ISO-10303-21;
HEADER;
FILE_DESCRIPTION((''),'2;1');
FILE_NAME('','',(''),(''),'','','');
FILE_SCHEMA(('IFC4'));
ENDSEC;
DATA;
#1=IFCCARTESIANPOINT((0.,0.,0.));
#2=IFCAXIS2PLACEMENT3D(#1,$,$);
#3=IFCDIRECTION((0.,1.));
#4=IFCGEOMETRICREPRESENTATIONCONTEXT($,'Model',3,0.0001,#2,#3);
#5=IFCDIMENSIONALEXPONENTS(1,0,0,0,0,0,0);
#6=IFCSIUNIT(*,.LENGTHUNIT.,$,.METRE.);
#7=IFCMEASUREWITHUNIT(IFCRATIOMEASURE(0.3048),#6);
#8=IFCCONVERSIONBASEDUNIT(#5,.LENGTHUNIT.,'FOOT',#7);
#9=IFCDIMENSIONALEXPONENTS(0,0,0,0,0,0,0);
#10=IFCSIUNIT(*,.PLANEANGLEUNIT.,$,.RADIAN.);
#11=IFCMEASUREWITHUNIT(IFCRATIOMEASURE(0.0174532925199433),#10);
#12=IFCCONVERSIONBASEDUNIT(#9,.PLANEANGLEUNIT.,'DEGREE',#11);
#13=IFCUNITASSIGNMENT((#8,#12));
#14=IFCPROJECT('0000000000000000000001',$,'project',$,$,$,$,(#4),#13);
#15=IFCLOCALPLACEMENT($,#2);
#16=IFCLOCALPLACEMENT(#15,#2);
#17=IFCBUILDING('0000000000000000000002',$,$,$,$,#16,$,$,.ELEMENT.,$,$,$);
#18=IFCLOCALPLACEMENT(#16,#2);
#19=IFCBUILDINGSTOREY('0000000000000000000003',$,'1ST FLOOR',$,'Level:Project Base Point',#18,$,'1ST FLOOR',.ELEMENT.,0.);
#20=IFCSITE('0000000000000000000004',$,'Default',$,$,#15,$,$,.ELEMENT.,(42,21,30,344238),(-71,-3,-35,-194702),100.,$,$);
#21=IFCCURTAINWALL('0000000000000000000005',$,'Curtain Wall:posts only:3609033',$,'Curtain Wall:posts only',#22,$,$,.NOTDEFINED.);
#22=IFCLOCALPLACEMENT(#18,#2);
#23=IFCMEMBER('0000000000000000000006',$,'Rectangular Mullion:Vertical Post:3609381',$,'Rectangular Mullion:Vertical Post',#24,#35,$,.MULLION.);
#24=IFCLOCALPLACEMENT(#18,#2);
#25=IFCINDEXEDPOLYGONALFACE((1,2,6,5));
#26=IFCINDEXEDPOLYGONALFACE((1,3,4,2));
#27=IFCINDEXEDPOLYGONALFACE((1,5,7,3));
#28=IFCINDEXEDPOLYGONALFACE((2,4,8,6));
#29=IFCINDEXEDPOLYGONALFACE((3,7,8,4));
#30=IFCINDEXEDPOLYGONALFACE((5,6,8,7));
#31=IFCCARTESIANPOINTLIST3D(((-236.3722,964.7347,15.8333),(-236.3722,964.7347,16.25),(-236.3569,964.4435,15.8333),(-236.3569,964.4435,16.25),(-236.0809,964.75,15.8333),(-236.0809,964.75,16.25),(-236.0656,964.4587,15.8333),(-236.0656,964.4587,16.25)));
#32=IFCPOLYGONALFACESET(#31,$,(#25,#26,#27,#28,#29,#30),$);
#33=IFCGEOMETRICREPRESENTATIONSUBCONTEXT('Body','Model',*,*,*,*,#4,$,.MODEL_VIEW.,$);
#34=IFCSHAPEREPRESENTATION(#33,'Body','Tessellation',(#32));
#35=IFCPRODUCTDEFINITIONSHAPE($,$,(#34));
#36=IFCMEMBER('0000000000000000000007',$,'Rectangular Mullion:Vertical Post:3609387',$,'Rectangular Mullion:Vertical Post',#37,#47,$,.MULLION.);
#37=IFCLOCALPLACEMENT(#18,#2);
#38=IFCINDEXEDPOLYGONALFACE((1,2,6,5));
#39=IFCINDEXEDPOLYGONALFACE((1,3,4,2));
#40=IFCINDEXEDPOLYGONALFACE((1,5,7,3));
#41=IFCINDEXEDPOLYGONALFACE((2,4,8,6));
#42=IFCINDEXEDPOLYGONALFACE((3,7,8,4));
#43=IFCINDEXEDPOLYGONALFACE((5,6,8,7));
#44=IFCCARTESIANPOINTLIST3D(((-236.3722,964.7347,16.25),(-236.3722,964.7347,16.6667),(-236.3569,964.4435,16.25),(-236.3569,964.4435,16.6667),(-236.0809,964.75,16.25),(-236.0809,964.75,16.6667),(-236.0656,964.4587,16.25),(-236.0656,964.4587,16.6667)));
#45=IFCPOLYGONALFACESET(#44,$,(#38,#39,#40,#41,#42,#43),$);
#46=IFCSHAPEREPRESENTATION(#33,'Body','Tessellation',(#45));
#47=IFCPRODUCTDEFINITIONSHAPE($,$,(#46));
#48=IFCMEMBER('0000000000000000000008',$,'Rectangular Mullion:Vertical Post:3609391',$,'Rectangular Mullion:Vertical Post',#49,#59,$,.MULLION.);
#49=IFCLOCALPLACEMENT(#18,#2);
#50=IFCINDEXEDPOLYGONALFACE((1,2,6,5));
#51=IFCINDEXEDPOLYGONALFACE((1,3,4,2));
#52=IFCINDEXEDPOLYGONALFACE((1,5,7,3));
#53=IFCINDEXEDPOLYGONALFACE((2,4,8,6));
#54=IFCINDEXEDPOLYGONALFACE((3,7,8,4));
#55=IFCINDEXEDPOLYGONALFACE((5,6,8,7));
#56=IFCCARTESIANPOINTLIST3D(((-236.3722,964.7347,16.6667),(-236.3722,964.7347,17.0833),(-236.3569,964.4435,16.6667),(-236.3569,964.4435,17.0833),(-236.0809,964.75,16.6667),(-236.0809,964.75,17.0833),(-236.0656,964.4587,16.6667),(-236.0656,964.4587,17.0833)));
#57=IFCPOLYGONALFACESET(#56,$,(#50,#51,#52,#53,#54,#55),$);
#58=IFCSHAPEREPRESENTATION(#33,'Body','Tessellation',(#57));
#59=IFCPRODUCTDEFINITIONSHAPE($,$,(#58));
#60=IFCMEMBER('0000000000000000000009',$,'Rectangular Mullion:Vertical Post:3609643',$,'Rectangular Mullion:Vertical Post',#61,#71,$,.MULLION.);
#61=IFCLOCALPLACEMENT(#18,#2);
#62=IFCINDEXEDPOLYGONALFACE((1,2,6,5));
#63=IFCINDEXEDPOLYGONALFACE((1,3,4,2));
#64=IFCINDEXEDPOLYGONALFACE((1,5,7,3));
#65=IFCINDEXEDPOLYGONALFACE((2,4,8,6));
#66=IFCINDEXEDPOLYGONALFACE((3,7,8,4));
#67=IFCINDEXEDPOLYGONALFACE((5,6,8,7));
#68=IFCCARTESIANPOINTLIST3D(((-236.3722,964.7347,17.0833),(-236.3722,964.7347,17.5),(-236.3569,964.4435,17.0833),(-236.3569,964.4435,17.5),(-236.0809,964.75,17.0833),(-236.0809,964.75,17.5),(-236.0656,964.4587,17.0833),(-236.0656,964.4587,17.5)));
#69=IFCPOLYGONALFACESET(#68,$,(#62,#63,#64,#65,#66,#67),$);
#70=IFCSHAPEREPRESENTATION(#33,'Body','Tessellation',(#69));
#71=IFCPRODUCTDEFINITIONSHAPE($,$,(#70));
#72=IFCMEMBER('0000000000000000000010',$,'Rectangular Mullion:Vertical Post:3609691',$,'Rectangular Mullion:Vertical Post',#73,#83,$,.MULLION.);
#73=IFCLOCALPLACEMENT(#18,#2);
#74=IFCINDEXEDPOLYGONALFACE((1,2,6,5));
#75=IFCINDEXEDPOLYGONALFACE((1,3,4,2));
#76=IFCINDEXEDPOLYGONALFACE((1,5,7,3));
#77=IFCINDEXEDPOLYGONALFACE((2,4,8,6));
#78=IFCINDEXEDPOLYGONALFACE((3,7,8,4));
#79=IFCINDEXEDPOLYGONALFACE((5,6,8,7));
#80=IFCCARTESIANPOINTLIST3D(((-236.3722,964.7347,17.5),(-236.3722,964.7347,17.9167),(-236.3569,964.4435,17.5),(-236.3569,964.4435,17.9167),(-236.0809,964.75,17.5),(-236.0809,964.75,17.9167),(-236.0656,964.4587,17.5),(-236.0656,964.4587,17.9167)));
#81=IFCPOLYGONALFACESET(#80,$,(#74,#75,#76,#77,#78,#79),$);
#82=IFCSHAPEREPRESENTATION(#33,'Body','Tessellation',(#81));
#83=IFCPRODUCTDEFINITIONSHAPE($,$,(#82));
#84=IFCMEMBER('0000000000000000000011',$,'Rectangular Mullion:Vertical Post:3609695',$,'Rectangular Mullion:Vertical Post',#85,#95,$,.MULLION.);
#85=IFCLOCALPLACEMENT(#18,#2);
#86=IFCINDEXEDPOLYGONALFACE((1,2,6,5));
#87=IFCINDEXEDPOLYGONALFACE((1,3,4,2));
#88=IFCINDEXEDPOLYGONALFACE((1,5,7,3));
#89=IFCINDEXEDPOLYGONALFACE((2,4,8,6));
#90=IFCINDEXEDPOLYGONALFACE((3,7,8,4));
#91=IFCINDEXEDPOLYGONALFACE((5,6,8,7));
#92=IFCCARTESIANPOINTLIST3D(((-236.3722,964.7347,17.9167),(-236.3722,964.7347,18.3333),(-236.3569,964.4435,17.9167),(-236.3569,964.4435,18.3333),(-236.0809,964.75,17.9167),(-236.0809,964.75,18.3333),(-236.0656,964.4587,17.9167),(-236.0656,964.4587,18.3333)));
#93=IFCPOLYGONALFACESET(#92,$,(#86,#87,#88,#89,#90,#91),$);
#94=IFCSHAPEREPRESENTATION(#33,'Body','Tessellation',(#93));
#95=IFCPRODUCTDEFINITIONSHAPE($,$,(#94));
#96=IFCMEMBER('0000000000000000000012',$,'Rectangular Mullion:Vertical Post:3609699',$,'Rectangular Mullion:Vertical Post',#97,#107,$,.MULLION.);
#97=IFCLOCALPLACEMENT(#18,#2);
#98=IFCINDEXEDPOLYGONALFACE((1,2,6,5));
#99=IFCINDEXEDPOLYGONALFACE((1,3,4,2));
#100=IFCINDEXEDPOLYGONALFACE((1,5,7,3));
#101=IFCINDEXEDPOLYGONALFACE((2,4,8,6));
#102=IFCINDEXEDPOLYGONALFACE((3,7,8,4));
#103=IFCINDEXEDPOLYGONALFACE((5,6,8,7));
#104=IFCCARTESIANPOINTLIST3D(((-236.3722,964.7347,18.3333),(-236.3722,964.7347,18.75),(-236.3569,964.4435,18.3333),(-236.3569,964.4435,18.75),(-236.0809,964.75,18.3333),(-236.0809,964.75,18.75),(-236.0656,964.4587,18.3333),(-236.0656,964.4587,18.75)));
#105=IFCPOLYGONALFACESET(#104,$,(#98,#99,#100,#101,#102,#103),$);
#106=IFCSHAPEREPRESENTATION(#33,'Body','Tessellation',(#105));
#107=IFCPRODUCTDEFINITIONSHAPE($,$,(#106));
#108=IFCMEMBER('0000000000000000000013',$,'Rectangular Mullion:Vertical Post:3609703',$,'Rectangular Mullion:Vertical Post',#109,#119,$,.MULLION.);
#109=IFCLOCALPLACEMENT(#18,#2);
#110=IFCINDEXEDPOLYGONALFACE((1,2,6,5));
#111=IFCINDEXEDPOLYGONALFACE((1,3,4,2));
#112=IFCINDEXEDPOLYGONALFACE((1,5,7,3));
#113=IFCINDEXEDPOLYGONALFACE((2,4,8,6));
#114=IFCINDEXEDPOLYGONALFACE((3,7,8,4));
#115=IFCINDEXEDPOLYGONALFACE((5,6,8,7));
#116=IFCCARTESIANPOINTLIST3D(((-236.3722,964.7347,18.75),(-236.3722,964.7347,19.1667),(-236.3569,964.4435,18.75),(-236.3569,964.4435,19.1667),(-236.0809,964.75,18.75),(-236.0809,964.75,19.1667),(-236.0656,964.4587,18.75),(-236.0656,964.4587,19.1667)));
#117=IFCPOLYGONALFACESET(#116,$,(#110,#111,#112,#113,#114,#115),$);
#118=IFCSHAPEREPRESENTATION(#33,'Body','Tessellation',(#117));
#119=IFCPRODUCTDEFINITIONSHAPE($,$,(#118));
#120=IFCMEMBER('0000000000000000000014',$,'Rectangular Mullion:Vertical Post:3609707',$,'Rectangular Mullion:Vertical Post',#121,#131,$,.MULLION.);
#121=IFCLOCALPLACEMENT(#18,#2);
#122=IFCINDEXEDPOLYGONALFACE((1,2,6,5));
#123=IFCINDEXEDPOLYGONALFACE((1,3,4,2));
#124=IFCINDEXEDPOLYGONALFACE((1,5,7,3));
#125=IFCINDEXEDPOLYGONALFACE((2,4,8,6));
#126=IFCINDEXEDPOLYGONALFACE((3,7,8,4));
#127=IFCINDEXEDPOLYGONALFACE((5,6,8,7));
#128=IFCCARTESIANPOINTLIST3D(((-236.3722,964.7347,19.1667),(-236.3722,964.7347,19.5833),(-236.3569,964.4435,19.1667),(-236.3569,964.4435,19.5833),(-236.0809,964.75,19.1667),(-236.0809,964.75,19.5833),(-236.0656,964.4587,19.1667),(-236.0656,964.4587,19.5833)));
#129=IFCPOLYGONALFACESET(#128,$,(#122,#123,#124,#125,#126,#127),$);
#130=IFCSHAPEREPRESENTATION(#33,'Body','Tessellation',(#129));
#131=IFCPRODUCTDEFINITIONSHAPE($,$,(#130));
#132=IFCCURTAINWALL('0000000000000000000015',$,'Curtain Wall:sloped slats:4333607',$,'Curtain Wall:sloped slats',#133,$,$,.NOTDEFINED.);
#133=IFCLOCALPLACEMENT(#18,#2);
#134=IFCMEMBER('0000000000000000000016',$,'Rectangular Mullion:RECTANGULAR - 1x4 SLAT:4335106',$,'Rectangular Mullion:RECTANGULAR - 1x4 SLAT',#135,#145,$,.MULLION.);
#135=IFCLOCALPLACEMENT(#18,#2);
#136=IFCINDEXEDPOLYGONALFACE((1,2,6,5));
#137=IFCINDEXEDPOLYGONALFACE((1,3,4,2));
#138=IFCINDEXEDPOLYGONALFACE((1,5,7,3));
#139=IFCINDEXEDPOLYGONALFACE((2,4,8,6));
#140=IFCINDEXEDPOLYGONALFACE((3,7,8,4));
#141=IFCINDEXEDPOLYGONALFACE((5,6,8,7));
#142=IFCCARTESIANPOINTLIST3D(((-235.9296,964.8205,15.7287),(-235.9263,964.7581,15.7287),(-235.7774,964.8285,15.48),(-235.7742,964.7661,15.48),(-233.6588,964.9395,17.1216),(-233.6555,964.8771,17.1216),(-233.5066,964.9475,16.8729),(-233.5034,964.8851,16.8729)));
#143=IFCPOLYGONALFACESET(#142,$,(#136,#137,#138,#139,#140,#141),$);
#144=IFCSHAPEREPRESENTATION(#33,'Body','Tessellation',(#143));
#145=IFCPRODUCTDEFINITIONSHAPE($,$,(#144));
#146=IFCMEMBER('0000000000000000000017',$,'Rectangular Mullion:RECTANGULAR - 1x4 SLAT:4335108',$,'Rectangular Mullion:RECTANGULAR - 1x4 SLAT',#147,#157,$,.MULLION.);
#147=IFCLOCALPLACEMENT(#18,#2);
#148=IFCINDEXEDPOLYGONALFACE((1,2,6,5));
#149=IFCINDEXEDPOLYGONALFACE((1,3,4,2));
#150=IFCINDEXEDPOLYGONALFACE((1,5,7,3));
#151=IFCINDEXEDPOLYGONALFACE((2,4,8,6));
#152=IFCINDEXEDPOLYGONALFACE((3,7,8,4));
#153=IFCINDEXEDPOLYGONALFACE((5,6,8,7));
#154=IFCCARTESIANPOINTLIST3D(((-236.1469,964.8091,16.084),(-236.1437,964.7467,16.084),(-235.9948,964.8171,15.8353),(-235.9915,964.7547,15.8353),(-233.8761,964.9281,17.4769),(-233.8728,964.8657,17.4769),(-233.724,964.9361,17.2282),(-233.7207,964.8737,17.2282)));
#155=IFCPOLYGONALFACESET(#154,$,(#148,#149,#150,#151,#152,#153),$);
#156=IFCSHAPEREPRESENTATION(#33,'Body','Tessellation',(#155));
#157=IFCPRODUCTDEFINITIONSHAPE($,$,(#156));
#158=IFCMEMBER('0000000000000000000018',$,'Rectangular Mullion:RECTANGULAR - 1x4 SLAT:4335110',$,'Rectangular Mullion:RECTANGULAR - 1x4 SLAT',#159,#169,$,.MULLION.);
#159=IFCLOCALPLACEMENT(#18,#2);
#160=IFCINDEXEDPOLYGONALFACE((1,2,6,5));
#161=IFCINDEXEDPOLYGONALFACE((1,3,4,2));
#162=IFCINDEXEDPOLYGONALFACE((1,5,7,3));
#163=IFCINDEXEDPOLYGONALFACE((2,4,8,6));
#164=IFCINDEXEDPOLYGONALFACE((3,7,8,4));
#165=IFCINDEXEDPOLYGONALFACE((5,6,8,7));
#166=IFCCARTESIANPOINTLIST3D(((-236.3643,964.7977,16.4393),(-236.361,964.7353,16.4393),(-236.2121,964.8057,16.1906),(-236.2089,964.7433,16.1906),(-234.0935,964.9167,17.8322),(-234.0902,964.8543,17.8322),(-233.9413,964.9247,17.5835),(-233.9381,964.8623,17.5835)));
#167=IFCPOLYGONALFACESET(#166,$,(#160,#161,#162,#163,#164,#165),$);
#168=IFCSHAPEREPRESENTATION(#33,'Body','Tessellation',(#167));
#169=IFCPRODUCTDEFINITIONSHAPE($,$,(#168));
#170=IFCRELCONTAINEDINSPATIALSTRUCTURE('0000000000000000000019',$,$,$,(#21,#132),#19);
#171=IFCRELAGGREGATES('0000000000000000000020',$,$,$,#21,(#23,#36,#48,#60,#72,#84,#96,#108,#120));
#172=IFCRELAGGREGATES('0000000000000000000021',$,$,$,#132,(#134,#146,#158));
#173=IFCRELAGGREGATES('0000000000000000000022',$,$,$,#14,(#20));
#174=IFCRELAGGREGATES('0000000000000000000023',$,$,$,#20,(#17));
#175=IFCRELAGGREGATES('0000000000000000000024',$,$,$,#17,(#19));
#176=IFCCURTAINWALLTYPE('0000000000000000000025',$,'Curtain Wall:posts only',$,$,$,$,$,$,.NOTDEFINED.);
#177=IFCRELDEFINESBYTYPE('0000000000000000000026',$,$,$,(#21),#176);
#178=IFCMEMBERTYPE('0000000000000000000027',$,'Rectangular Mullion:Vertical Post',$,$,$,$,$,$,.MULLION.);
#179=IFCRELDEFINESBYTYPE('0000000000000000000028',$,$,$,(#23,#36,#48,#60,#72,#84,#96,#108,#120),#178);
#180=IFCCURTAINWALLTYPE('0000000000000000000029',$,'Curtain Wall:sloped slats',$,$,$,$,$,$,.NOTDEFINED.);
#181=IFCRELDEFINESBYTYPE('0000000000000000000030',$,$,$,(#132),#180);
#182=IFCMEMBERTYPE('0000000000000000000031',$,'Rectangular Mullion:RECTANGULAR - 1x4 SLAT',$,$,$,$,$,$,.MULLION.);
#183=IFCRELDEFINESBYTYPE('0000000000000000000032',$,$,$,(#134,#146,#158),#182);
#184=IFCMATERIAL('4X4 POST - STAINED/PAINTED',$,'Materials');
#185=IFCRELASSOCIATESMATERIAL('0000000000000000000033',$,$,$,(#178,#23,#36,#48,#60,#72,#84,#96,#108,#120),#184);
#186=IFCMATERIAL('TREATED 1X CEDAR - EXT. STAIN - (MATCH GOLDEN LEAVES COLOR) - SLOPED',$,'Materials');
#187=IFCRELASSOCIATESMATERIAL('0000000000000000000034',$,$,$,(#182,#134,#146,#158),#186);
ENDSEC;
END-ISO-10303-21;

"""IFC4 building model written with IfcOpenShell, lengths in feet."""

from ifc_helpers import new_model, entity, si_unit, converted_unit, direction, frame, frame_2d, origin, origin_2d_with_axis, place, context, subcontext, project, spatial, rectangle, extrude, source, transform, mapped, material, material_profile, profile_set, profile_usage, type_object, type_shapes, element, aggregate, save


model = new_model("IFC4")

# Units and contexts
model_context = context("Model", 3, precision=0.0001, world=origin(), true_north=direction((0.0, 1.0)))
body_context = subcontext(model_context, "Body", "Model", "MODEL_VIEW")
ifc_project = project(units=[converted_unit("LENGTHUNIT", "FOOT", entity("IfcRatioMeasure", 0.3048), si_unit("LENGTHUNIT", "METRE"), dimensions=[1, 0, 0, 0, 0, 0, 0]), converted_unit("PLANEANGLEUNIT", "DEGREE", entity("IfcRatioMeasure", 0.0174532925199433), si_unit("PLANEANGLEUNIT", "RADIAN"), dimensions=[0, 0, 0, 0, 0, 0, 0])], contexts=[model_context])

# Site, building, storey
site_placement = place(None, origin())
site = spatial("IfcSite", under=ifc_project, at=site_placement, Name="Default", CompositionType="ELEMENT", RefLatitude=(42, 21, 30, 344238), RefLongitude=(-71, -3, -35, -194702), RefElevation=100.0)
building_placement = place(site_placement, origin())
building = spatial("IfcBuilding", under=site, at=building_placement, CompositionType="ELEMENT")
storey_placement = place(building_placement, origin())
storey = spatial("IfcBuildingStorey", under=building, at=storey_placement, Name="1ST FLOOR", ObjectType="Level:Project Base Point", LongName="1ST FLOOR", CompositionType="ELEMENT", Elevation=0.0)

# Curtain walls, members
curtain_wall_type_1 = type_object("IfcCurtainWallType", Name="Curtain Wall:posts only", PredefinedType="NOTDEFINED")
curtain_wall_1_placement = place(storey_placement, origin())
curtain_wall_1 = element("IfcCurtainWall", 1, at=curtain_wall_1_placement, inside=storey, type_object=curtain_wall_type_1, Name="Curtain Wall:posts only:3609033", ObjectType="Curtain Wall:posts only", PredefinedType="NOTDEFINED")
ifc_material_1 = material(Name="4X4 POST - STAINED/PAINTED", Category="Materials")
ifc_material_profile_1 = material_profile(ifc_material_1, rectangle(XDim=0.2917, YDim=0.2917, at=origin_2d_with_axis()), Name="Vertical Post")
ifc_profile_set_1 = profile_set([ifc_material_profile_1], Name="Vertical Post")
member_type_1 = type_object("IfcMemberType", Name="Rectangular Mullion:Vertical Post", PredefinedType="MULLION", material=ifc_profile_set_1)
shared_shape_1 = source(origin(), body_context, "Body", "SweptSolid", [
    extrude(rectangle(XDim=0.2917, YDim=0.2917, at=origin_2d_with_axis()), frame((0.0, -0.2083, -0.4167), z_axis=(0.0, 0.0, 1.0), x_axis=(0.0, -1.0, 0.0)), (0.0, 0.0, 1.0), 0.4167),
])
type_shapes(member_type_1, [shared_shape_1])
ifc_profile_usage_1 = profile_usage(ifc_profile_set_1)
member_1_placement = place(storey_placement, frame((-236.2298, 964.8048, 15.8333), z_axis=(0.0, 0.0, -1.0), x_axis=(-0.99863, -0.052336, 0.0)))
member_1 = element("IfcMember", 2, at=member_1_placement, type_object=member_type_1, material=ifc_profile_usage_1, Name="Rectangular Mullion:Vertical Post:3609381", ObjectType="Rectangular Mullion:Vertical Post", PredefinedType="MULLION", context=body_context, shape_type="MappedRepresentation", body=[
    mapped(shared_shape_1, transform((0.0, 0.0, 0.0), scale=1.0)),
])
ifc_profile_usage_2 = profile_usage(ifc_profile_set_1)
member_2_placement = place(storey_placement, frame((-236.2298, 964.8048, 16.25), z_axis=(0.0, 0.0, -1.0), x_axis=(-0.99863, -0.052336, 0.0)))
member_2 = element("IfcMember", 3, at=member_2_placement, type_object=member_type_1, material=ifc_profile_usage_2, Name="Rectangular Mullion:Vertical Post:3609387", ObjectType="Rectangular Mullion:Vertical Post", PredefinedType="MULLION", context=body_context, shape_type="MappedRepresentation", body=[
    mapped(shared_shape_1, transform((0.0, 0.0, 0.0), scale=1.0)),
])
ifc_profile_usage_3 = profile_usage(ifc_profile_set_1)
member_3_placement = place(storey_placement, frame((-236.2298, 964.8048, 16.6667), z_axis=(0.0, 0.0, -1.0), x_axis=(-0.99863, -0.052336, 0.0)))
member_3 = element("IfcMember", 4, at=member_3_placement, type_object=member_type_1, material=ifc_profile_usage_3, Name="Rectangular Mullion:Vertical Post:3609391", ObjectType="Rectangular Mullion:Vertical Post", PredefinedType="MULLION", context=body_context, shape_type="MappedRepresentation", body=[
    mapped(shared_shape_1, transform((0.0, 0.0, 0.0), scale=1.0)),
])
ifc_profile_usage_4 = profile_usage(ifc_profile_set_1)
member_4_placement = place(storey_placement, frame((-236.2298, 964.8048, 17.0833), z_axis=(0.0, 0.0, -1.0), x_axis=(-0.99863, -0.052336, 0.0)))
member_4 = element("IfcMember", 5, at=member_4_placement, type_object=member_type_1, material=ifc_profile_usage_4, Name="Rectangular Mullion:Vertical Post:3609643", ObjectType="Rectangular Mullion:Vertical Post", PredefinedType="MULLION", context=body_context, shape_type="MappedRepresentation", body=[
    mapped(shared_shape_1, transform((0.0, 0.0, 0.0), scale=1.0)),
])
ifc_profile_usage_5 = profile_usage(ifc_profile_set_1)
member_5_placement = place(storey_placement, frame((-236.2298, 964.8048, 17.5), z_axis=(0.0, 0.0, -1.0), x_axis=(-0.99863, -0.052336, 0.0)))
member_5 = element("IfcMember", 6, at=member_5_placement, type_object=member_type_1, material=ifc_profile_usage_5, Name="Rectangular Mullion:Vertical Post:3609691", ObjectType="Rectangular Mullion:Vertical Post", PredefinedType="MULLION", context=body_context, shape_type="MappedRepresentation", body=[
    mapped(shared_shape_1, transform((0.0, 0.0, 0.0), scale=1.0)),
])
ifc_profile_usage_6 = profile_usage(ifc_profile_set_1)
member_6_placement = place(storey_placement, frame((-236.2298, 964.8048, 17.9167), z_axis=(0.0, 0.0, -1.0), x_axis=(-0.99863, -0.052336, 0.0)))
member_6 = element("IfcMember", 7, at=member_6_placement, type_object=member_type_1, material=ifc_profile_usage_6, Name="Rectangular Mullion:Vertical Post:3609695", ObjectType="Rectangular Mullion:Vertical Post", PredefinedType="MULLION", context=body_context, shape_type="MappedRepresentation", body=[
    mapped(shared_shape_1, transform((0.0, 0.0, 0.0), scale=1.0)),
])
ifc_profile_usage_7 = profile_usage(ifc_profile_set_1)
member_7_placement = place(storey_placement, frame((-236.2298, 964.8048, 18.3333), z_axis=(0.0, 0.0, -1.0), x_axis=(-0.99863, -0.052336, 0.0)))
member_7 = element("IfcMember", 8, at=member_7_placement, type_object=member_type_1, material=ifc_profile_usage_7, Name="Rectangular Mullion:Vertical Post:3609699", ObjectType="Rectangular Mullion:Vertical Post", PredefinedType="MULLION", context=body_context, shape_type="MappedRepresentation", body=[
    mapped(shared_shape_1, transform((0.0, 0.0, 0.0), scale=1.0)),
])
ifc_profile_usage_8 = profile_usage(ifc_profile_set_1)
member_8_placement = place(storey_placement, frame((-236.2298, 964.8048, 18.75), z_axis=(0.0, 0.0, -1.0), x_axis=(-0.99863, -0.052336, 0.0)))
member_8 = element("IfcMember", 9, at=member_8_placement, type_object=member_type_1, material=ifc_profile_usage_8, Name="Rectangular Mullion:Vertical Post:3609703", ObjectType="Rectangular Mullion:Vertical Post", PredefinedType="MULLION", context=body_context, shape_type="MappedRepresentation", body=[
    mapped(shared_shape_1, transform((0.0, 0.0, 0.0), scale=1.0)),
])
ifc_profile_usage_9 = profile_usage(ifc_profile_set_1)
member_9_placement = place(storey_placement, frame((-236.2298, 964.8048, 19.1667), z_axis=(0.0, 0.0, -1.0), x_axis=(-0.99863, -0.052336, 0.0)))
member_9 = element("IfcMember", 10, at=member_9_placement, type_object=member_type_1, material=ifc_profile_usage_9, Name="Rectangular Mullion:Vertical Post:3609707", ObjectType="Rectangular Mullion:Vertical Post", PredefinedType="MULLION", context=body_context, shape_type="MappedRepresentation", body=[
    mapped(shared_shape_1, transform((0.0, 0.0, 0.0), scale=1.0)),
])
aggregate(curtain_wall_1, [member_1, member_2, member_3, member_4, member_5, member_6, member_7, member_8, member_9])
curtain_wall_type_2 = type_object("IfcCurtainWallType", Name="Curtain Wall:sloped slats", PredefinedType="NOTDEFINED")
curtain_wall_2_placement = place(storey_placement, origin())
curtain_wall_2 = element("IfcCurtainWall", 11, at=curtain_wall_2_placement, inside=storey, type_object=curtain_wall_type_2, Name="Curtain Wall:sloped slats:4333607", ObjectType="Curtain Wall:sloped slats", PredefinedType="NOTDEFINED")
ifc_material_2 = material(Name="TREATED 1X CEDAR - EXT. STAIN - (MATCH GOLDEN LEAVES COLOR) - SLOPED", Category="Materials")
ifc_material_profile_2 = material_profile(ifc_material_2, rectangle(XDim=0.0625, YDim=0.2917, at=frame_2d((0.0, 0.0), x_axis=(1.0, 0.0))), Name="RECTANGULAR - 1x4 SLAT")
ifc_profile_set_2 = profile_set([ifc_material_profile_2], Name="RECTANGULAR - 1x4 SLAT")
ifc_profile_usage_10 = profile_usage(ifc_profile_set_2)
member_type_2 = type_object("IfcMemberType", Name="Rectangular Mullion:RECTANGULAR - 1x4 SLAT", PredefinedType="MULLION", material=ifc_profile_set_2)
shared_shape_2 = source(origin(), body_context, "Body", "SweptSolid", [
    extrude(rectangle(XDim=0.0625, YDim=0.2917, at=frame_2d((0.0, 0.0), x_axis=(1.0, 0.0))), frame((0.0, 0.0, -2.6667), z_axis=(0.0, 0.0, 1.0), x_axis=(0.0, -1.0, 0.0)), (0.0, 0.0, 1.0), 2.6667),
])
type_shapes(member_type_2, [shared_shape_2])
member_10_placement = place(storey_placement, frame((-235.8519, 964.7933, 15.6043), z_axis=(-0.851559, -0.044628, -0.522356), x_axis=(-0.52164, -0.027338, 0.852727)))
member_10 = element("IfcMember", 12, at=member_10_placement, type_object=member_type_2, material=ifc_profile_usage_10, Name="Rectangular Mullion:RECTANGULAR - 1x4 SLAT:4335106", ObjectType="Rectangular Mullion:RECTANGULAR - 1x4 SLAT", PredefinedType="MULLION", context=body_context, shape_type="MappedRepresentation", body=[
    mapped(shared_shape_2, transform((0.0, 0.0, 0.0), scale=1.0)),
])
ifc_profile_usage_11 = profile_usage(ifc_profile_set_2)
member_11_placement = place(storey_placement, frame((-236.0692, 964.7819, 15.9596), z_axis=(-0.851559, -0.044628, -0.522356), x_axis=(-0.52164, -0.027338, 0.852727)))
member_11 = element("IfcMember", 13, at=member_11_placement, type_object=member_type_2, material=ifc_profile_usage_11, Name="Rectangular Mullion:RECTANGULAR - 1x4 SLAT:4335108", ObjectType="Rectangular Mullion:RECTANGULAR - 1x4 SLAT", PredefinedType="MULLION", context=body_context, shape_type="MappedRepresentation", body=[
    mapped(shared_shape_2, transform((0.0, 0.0, 0.0), scale=1.0)),
])
ifc_profile_usage_12 = profile_usage(ifc_profile_set_2)
member_12_placement = place(storey_placement, frame((-236.2866, 964.7705, 16.3149), z_axis=(-0.851559, -0.044628, -0.522356), x_axis=(-0.52164, -0.027338, 0.852727)))
member_12 = element("IfcMember", 14, at=member_12_placement, type_object=member_type_2, material=ifc_profile_usage_12, Name="Rectangular Mullion:RECTANGULAR - 1x4 SLAT:4335110", ObjectType="Rectangular Mullion:RECTANGULAR - 1x4 SLAT", PredefinedType="MULLION", context=body_context, shape_type="MappedRepresentation", body=[
    mapped(shared_shape_2, transform((0.0, 0.0, 0.0), scale=1.0)),
])
aggregate(curtain_wall_2, [member_10, member_11, member_12])

save(model, "model.ifc")
